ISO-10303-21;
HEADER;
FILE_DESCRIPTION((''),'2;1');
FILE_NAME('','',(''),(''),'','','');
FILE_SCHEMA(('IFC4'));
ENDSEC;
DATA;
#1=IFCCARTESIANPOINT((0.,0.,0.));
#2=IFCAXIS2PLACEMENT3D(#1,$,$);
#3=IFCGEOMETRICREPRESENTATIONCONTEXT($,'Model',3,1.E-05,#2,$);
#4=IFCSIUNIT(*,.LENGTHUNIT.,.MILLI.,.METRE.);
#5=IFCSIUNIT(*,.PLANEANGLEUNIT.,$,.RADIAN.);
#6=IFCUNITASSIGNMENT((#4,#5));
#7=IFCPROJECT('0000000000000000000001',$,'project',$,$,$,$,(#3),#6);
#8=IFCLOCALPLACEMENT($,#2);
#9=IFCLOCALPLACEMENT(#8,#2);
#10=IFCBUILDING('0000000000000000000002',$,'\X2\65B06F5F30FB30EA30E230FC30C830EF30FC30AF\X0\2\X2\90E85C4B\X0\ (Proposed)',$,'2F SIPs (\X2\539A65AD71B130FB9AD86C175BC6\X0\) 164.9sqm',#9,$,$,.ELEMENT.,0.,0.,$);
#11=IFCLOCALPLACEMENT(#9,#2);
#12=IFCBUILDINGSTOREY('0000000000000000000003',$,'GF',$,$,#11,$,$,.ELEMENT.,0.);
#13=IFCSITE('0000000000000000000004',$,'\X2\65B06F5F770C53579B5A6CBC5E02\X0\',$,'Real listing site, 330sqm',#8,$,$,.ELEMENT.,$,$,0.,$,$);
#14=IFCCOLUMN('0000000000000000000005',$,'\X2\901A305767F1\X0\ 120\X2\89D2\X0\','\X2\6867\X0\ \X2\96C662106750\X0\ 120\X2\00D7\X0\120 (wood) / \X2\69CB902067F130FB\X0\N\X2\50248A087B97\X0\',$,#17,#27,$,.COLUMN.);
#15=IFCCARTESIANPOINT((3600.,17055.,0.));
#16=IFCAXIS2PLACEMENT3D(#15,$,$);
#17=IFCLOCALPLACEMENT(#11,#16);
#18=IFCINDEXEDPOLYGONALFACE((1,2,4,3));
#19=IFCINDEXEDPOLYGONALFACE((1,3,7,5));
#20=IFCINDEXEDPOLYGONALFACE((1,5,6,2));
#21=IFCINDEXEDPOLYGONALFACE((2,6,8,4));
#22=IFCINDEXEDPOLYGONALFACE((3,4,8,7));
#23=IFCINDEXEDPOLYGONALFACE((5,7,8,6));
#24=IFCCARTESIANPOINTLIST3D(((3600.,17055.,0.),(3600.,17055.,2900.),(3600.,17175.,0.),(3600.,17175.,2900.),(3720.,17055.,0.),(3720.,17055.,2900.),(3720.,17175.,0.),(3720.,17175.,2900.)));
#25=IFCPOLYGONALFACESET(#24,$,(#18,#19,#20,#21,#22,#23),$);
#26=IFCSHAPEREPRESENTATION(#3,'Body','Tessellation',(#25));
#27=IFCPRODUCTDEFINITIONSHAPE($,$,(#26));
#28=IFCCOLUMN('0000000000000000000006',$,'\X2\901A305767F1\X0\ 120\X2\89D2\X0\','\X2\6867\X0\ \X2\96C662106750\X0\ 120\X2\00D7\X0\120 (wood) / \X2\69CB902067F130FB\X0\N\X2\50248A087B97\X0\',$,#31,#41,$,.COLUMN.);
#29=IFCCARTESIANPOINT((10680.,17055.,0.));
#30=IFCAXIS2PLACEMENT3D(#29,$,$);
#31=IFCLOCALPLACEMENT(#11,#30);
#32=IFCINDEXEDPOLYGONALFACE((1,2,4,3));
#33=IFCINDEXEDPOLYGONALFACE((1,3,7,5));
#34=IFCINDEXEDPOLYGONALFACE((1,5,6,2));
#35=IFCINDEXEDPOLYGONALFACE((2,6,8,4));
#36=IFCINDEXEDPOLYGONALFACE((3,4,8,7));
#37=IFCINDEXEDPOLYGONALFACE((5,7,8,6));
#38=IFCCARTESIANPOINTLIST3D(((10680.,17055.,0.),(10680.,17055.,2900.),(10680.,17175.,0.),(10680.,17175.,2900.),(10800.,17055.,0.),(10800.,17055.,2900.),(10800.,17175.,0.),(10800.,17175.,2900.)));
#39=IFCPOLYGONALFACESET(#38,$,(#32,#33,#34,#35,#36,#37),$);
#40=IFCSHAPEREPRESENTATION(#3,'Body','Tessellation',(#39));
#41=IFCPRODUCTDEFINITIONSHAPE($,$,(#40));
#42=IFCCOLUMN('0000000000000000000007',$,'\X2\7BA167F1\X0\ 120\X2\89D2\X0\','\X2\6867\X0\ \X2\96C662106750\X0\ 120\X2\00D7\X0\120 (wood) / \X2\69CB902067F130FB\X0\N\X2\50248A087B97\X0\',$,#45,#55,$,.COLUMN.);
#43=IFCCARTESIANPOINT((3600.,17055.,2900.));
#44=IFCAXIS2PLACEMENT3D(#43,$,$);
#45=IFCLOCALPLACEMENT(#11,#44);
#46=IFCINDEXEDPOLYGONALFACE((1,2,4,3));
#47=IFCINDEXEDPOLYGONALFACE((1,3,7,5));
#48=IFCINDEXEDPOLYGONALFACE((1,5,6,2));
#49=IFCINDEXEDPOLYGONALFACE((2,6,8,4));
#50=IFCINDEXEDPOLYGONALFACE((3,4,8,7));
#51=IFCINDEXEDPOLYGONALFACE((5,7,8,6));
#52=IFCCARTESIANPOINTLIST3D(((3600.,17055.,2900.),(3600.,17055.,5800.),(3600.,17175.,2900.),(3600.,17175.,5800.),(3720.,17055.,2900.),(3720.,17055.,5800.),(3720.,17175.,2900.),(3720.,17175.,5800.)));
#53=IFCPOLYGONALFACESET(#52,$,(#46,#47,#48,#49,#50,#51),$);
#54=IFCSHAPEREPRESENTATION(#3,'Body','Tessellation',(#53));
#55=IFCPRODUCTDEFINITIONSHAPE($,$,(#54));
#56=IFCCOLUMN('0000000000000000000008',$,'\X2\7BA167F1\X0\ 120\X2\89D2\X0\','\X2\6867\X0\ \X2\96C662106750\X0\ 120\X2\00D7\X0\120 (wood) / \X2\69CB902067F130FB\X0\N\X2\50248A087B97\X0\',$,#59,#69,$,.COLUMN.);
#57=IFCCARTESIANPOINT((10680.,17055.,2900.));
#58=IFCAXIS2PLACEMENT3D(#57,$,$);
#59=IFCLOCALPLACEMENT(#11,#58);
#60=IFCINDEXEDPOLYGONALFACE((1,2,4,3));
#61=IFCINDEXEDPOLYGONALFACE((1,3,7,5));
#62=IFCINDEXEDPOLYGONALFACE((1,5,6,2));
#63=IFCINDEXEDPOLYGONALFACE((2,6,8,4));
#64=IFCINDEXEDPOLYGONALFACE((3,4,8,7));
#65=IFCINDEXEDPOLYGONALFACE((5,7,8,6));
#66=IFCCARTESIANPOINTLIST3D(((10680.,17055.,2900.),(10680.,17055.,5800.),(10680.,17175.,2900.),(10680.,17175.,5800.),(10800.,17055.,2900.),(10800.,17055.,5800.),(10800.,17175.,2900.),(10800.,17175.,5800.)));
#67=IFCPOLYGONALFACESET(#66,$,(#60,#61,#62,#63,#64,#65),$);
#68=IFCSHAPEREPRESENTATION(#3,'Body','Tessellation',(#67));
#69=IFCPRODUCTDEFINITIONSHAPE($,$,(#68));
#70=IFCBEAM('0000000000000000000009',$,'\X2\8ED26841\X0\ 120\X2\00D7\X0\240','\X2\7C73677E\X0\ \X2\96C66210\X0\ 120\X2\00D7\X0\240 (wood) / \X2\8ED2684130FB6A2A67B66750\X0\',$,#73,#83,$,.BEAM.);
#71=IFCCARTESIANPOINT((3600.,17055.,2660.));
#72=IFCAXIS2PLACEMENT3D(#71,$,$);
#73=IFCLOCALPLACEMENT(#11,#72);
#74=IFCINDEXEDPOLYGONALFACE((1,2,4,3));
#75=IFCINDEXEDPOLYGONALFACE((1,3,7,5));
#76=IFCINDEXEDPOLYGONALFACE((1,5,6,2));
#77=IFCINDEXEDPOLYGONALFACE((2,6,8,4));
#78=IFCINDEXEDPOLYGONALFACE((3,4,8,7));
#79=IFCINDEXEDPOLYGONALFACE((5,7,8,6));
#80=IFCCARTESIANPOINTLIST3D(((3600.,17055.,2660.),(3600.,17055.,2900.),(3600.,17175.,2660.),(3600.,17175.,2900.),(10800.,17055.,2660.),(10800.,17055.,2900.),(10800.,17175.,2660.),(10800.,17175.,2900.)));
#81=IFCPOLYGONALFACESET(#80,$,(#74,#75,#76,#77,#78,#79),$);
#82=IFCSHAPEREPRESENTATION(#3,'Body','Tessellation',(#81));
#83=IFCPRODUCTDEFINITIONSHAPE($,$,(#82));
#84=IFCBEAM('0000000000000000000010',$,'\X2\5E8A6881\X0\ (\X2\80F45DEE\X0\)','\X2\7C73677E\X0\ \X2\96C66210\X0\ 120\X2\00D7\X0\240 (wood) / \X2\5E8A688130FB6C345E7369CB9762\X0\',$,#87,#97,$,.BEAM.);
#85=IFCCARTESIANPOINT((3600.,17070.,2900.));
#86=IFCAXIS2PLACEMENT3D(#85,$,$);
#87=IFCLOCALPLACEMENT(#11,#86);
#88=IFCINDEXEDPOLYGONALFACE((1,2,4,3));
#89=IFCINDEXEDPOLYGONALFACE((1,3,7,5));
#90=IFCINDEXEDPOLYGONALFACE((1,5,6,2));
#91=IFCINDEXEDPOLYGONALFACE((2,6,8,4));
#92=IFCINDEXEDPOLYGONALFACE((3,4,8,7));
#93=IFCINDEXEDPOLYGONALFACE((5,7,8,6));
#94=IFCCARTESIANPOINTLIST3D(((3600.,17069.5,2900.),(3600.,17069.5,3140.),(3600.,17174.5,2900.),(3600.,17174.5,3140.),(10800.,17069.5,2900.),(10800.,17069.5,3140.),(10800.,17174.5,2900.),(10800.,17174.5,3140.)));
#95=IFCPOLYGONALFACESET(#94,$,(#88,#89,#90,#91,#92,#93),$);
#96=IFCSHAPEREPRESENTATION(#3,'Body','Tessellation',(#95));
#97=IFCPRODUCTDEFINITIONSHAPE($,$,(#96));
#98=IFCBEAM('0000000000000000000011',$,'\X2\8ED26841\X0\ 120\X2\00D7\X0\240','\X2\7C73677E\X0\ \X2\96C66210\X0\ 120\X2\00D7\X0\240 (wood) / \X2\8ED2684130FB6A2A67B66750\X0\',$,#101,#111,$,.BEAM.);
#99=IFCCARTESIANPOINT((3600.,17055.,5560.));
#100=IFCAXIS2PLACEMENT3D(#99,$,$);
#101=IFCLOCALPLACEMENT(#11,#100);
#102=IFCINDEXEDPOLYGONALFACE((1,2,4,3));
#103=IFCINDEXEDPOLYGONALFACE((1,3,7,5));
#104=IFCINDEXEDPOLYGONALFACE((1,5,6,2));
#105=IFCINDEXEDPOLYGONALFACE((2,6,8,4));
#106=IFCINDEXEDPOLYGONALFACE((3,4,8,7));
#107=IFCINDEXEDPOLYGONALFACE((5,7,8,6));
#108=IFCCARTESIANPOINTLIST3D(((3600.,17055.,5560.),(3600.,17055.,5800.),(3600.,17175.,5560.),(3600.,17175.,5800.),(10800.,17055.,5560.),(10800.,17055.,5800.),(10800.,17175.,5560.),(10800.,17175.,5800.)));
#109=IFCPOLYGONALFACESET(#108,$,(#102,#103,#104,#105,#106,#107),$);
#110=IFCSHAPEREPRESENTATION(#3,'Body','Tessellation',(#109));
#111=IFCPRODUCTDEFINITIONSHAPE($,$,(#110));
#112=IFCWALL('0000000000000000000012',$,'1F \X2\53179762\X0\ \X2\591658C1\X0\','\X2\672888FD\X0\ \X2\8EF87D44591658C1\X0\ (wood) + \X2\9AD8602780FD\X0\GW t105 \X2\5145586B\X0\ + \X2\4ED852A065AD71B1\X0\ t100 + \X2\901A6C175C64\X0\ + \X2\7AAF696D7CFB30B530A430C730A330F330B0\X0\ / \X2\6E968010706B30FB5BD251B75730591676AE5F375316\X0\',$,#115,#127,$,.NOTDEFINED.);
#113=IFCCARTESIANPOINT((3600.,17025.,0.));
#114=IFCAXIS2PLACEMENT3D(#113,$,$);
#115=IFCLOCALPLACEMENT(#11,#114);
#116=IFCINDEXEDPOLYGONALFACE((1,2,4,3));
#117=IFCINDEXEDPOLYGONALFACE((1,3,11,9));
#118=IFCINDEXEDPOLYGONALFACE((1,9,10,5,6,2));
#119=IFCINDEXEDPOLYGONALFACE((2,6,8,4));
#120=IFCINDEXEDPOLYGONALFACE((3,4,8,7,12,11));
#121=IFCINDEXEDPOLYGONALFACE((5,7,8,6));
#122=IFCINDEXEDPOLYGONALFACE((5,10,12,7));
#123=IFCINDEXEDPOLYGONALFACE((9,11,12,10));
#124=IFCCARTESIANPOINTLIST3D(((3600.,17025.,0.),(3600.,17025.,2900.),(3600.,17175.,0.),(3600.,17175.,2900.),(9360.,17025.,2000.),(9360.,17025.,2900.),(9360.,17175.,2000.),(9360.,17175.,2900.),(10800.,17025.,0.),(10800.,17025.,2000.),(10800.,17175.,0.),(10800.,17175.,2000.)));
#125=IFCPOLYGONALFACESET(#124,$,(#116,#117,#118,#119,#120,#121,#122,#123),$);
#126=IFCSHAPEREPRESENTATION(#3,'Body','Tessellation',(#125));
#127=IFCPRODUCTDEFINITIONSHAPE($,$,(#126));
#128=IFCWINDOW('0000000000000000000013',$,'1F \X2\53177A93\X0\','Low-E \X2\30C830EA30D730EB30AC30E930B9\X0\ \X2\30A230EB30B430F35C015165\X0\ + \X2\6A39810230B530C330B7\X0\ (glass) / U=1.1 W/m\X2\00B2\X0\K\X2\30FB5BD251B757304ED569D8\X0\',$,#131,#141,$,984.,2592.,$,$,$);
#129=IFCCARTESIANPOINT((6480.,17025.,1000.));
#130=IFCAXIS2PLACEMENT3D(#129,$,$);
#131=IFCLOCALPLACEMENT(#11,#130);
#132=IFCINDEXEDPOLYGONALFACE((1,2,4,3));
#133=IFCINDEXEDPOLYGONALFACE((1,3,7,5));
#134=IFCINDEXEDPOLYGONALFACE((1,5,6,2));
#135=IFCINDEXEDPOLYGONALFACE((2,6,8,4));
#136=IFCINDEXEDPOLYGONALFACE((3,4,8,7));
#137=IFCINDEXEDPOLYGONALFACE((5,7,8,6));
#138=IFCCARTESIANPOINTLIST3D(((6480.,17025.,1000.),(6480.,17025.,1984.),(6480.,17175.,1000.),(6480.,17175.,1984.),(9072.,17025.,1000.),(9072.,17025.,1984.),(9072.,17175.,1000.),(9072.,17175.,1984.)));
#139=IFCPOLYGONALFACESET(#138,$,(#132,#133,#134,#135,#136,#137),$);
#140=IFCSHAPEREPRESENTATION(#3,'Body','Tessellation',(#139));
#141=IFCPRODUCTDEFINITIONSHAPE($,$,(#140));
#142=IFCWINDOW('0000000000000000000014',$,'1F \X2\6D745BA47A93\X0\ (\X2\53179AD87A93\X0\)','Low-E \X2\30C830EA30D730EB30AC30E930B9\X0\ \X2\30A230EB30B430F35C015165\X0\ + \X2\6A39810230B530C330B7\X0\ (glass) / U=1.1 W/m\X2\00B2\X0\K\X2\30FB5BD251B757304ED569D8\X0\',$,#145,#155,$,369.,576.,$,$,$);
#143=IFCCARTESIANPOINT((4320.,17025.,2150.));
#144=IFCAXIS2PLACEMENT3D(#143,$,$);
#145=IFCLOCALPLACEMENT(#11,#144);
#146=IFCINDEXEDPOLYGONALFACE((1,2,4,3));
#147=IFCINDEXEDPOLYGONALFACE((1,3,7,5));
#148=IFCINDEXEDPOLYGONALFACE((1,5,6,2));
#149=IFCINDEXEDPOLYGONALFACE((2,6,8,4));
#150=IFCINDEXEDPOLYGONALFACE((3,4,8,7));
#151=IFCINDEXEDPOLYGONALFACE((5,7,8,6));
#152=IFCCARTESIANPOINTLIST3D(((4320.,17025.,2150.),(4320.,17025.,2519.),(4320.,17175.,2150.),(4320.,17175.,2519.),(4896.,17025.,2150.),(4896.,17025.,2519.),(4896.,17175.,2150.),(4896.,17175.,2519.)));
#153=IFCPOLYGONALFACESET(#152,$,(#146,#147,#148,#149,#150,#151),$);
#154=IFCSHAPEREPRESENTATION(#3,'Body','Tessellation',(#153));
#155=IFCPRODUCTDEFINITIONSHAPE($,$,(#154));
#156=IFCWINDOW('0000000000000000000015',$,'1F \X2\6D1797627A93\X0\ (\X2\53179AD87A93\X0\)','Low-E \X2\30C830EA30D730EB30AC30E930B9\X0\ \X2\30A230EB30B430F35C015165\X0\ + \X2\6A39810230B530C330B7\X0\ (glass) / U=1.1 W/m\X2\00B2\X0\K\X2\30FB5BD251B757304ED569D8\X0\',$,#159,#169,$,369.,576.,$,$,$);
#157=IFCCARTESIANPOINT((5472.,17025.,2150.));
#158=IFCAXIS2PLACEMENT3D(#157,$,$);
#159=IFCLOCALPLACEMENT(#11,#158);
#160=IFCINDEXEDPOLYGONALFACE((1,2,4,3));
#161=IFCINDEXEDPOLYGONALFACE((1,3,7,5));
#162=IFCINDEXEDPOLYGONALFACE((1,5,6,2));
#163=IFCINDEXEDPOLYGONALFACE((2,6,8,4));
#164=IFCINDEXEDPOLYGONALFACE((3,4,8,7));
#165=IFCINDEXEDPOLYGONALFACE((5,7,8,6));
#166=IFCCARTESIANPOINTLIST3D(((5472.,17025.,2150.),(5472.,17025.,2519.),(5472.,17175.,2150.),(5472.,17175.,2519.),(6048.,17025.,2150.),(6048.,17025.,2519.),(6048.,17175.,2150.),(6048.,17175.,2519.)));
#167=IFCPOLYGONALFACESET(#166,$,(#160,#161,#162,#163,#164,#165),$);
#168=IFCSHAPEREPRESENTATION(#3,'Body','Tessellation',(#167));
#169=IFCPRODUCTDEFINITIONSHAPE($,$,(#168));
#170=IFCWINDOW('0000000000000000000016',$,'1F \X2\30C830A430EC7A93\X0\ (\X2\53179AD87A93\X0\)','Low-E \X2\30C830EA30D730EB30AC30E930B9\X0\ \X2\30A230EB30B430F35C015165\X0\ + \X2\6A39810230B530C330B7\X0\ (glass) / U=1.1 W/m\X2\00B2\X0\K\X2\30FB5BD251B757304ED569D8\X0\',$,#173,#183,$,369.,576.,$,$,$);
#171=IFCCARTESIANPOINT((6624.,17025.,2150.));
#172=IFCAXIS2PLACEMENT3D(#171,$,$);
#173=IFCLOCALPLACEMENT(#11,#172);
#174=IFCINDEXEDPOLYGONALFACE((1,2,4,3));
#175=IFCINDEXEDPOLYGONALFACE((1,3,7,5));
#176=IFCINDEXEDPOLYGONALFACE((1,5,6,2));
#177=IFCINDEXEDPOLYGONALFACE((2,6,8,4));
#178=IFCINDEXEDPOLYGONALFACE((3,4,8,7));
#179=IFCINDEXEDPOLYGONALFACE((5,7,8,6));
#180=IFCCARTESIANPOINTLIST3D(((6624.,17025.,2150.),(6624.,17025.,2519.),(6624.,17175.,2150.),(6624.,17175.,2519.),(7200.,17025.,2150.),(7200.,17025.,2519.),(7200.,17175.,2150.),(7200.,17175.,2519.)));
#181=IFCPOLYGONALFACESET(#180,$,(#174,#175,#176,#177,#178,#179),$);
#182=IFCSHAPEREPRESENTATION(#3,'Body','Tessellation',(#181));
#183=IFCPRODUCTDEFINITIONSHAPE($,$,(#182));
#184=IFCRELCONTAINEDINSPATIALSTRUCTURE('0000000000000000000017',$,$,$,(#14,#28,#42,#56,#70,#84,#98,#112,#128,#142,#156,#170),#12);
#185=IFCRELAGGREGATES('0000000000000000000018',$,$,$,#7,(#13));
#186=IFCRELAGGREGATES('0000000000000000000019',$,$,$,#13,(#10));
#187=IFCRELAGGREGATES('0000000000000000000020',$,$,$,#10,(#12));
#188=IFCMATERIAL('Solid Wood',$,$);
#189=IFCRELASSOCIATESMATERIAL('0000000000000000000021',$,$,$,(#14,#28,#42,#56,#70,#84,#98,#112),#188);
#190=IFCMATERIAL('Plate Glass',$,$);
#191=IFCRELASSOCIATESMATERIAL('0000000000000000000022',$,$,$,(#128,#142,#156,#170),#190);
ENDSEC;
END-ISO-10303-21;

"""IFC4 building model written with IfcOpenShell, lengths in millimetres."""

from ifc_helpers import new_model, si_unit, frame, frame_2d, origin, place, context, project, spatial, rectangle, extrude, material, element, fill, save


model = new_model("IFC4")

# Units and contexts
model_context = context("Model", 3, precision=1e-05, world=origin())
ifc_project = project(units=[si_unit("LENGTHUNIT", "METRE", prefix="MILLI"), si_unit("PLANEANGLEUNIT", "RADIAN")], contexts=[model_context])

# Site, building, storey
site_placement = place(None, origin())
site = spatial("IfcSite", under=ifc_project, at=site_placement, Name="新潟県南魚沼市", ObjectType="Real listing site, 330sqm", CompositionType="ELEMENT", RefElevation=0.0)
building_placement = place(site_placement, origin())
building = spatial("IfcBuilding", under=site, at=building_placement, Name="新潟・リモートワーク2部屋 (Proposed)", ObjectType="2F SIPs (厚断熱・高気密) 164.9sqm", CompositionType="ELEMENT", ElevationOfRefHeight=0.0, ElevationOfTerrain=0.0)
storey_placement = place(building_placement, origin())
storey = spatial("IfcBuildingStorey", under=building, at=storey_placement, Name="GF", CompositionType="ELEMENT", Elevation=0.0)

# Columns
ifc_material_1 = material(Name="Solid Wood")
column_1_placement = place(storey_placement, frame((3600.0, 17055.0, 0.0)))
element("IfcColumn", 1, at=column_1_placement, inside=storey, material=ifc_material_1, Name="通し柱 120角", Description="桧 集成材 120×120 (wood) / 構造柱・N値計算", PredefinedType="COLUMN", context=model_context, shape_type="SweptSolid", body=[
    extrude(rectangle(XDim=120.0, YDim=120.0, at=frame_2d((60.0, 60.0))), frame((3600.0, 17055.0, 0.0)), (0.0, 0.0, 1.0), 2900.0),
])
column_2_placement = place(storey_placement, frame((10680.0, 17055.0, 0.0)))
element("IfcColumn", 2, at=column_2_placement, inside=storey, material=ifc_material_1, Name="通し柱 120角", Description="桧 集成材 120×120 (wood) / 構造柱・N値計算", PredefinedType="COLUMN", context=model_context, shape_type="SweptSolid", body=[
    extrude(rectangle(XDim=120.0, YDim=120.0, at=frame_2d((60.0, 60.0))), frame((10680.0, 17055.0, 0.0)), (0.0, 0.0, 1.0), 2900.0),
])
column_3_placement = place(storey_placement, frame((3600.0, 17055.0, 2900.0)))
element("IfcColumn", 3, at=column_3_placement, inside=storey, material=ifc_material_1, Name="管柱 120角", Description="桧 集成材 120×120 (wood) / 構造柱・N値計算", PredefinedType="COLUMN", context=model_context, shape_type="SweptSolid", body=[
    extrude(rectangle(XDim=120.0, YDim=120.0, at=frame_2d((60.0, 60.0))), frame((3600.0, 17055.0, 2900.0)), (0.0, 0.0, 1.0), 2900.0),
])
column_4_placement = place(storey_placement, frame((10680.0, 17055.0, 2900.0)))
element("IfcColumn", 4, at=column_4_placement, inside=storey, material=ifc_material_1, Name="管柱 120角", Description="桧 集成材 120×120 (wood) / 構造柱・N値計算", PredefinedType="COLUMN", context=model_context, shape_type="SweptSolid", body=[
    extrude(rectangle(XDim=120.0, YDim=120.0, at=frame_2d((60.0, 60.0))), frame((10680.0, 17055.0, 2900.0)), (0.0, 0.0, 1.0), 2900.0),
])

# Beams
beam_1_placement = place(storey_placement, frame((3600.0, 17055.0, 2660.0)))
element("IfcBeam", 5, at=beam_1_placement, inside=storey, material=ifc_material_1, Name="軒桁 120×240", Description="米松 集成 120×240 (wood) / 軒桁・横架材", PredefinedType="BEAM", context=model_context, shape_type="SweptSolid", body=[
    extrude(rectangle(XDim=7200.0, YDim=120.0, at=frame_2d((3600.0, 60.0))), frame((3600.0, 17055.0, 2660.0)), (0.0, 0.0, 1.0), 240.0),
])
beam_2_placement = place(storey_placement, frame((3600.0, 17070.0, 2900.0)))
element("IfcBeam", 6, at=beam_2_placement, inside=storey, material=ifc_material_1, Name="床梁 (胴差)", Description="米松 集成 120×240 (wood) / 床梁・水平構面", PredefinedType="BEAM", context=model_context, shape_type="SweptSolid", body=[
    extrude(rectangle(XDim=7200.0, YDim=105.0, at=frame_2d((3600.0, 52.0))), frame((3600.0, 17070.0, 2900.0)), (0.0, 0.0, 1.0), 240.0),
])
beam_3_placement = place(storey_placement, frame((3600.0, 17055.0, 5560.0)))
element("IfcBeam", 7, at=beam_3_placement, inside=storey, material=ifc_material_1, Name="軒桁 120×240", Description="米松 集成 120×240 (wood) / 軒桁・横架材", PredefinedType="BEAM", context=model_context, shape_type="SweptSolid", body=[
    extrude(rectangle(XDim=7200.0, YDim=120.0, at=frame_2d((3600.0, 60.0))), frame((3600.0, 17055.0, 5560.0)), (0.0, 0.0, 1.0), 240.0),
])

# Wall, openings, windows
wall_1_placement = place(storey_placement, frame((3600.0, 17025.0, 0.0)))
wall_1 = element("IfcWall", 8, at=wall_1_placement, inside=storey, material=ifc_material_1, Name="1F 北面 外壁", Description="木製 軸組外壁 (wood) + 高性能GW t105 充填 + 付加断熱 t100 + 通気層 + 窯業系サイディング / 準耐火・寒冷地外皮強化", PredefinedType="NOTDEFINED", context=model_context, shape_type="SweptSolid", body=[
    extrude(rectangle(XDim=7200.0, YDim=150.0, at=frame_2d((3600.0, 75.0))), frame((3600.0, 17025.0, 0.0)), (0.0, 0.0, 1.0), 2900.0),
])
opening_1_placement = place(storey_placement, frame((6480.0, 17025.0, 1000.0)))
opening_1 = element("IfcOpeningElement", 9, at=opening_1_placement, cuts=wall_1, PredefinedType="NOTDEFINED", context=model_context, shape_type="SweptSolid", body=[
    extrude(rectangle(XDim=2592.0, YDim=150.0, at=frame_2d((1296.0, 75.0))), frame((6480.0, 17025.0, 1000.0)), (0.0, 0.0, 1.0), 984.0),
])
opening_2_placement = place(storey_placement, frame((4320.0, 17025.0, 2150.0)))
opening_2 = element("IfcOpeningElement", 10, at=opening_2_placement, cuts=wall_1, PredefinedType="NOTDEFINED", context=model_context, shape_type="SweptSolid", body=[
    extrude(rectangle(XDim=576.0, YDim=150.0, at=frame_2d((288.0, 75.0))), frame((4320.0, 17025.0, 2150.0)), (0.0, 0.0, 1.0), 369.0),
])
opening_3_placement = place(storey_placement, frame((5472.0, 17025.0, 2150.0)))
opening_3 = element("IfcOpeningElement", 11, at=opening_3_placement, cuts=wall_1, PredefinedType="NOTDEFINED", context=model_context, shape_type="SweptSolid", body=[
    extrude(rectangle(XDim=576.0, YDim=150.0, at=frame_2d((288.0, 75.0))), frame((5472.0, 17025.0, 2150.0)), (0.0, 0.0, 1.0), 369.0),
])
opening_4_placement = place(storey_placement, frame((6624.0, 17025.0, 2150.0)))
opening_4 = element("IfcOpeningElement", 12, at=opening_4_placement, cuts=wall_1, PredefinedType="NOTDEFINED", context=model_context, shape_type="SweptSolid", body=[
    extrude(rectangle(XDim=576.0, YDim=150.0, at=frame_2d((288.0, 75.0))), frame((6624.0, 17025.0, 2150.0)), (0.0, 0.0, 1.0), 369.0),
])
ifc_material_2 = material(Name="Plate Glass")
window_1_placement = place(storey_placement, frame((6480.0, 17025.0, 1000.0)))
window_1 = element("IfcWindow", 13, at=window_1_placement, inside=storey, material=ifc_material_2, Name="1F 北窓", Description="Low-E トリプルガラス アルゴン封入 + 樹脂サッシ (glass) / U=1.1 W/m²K・寒冷地仕様", OverallHeight=984.0, OverallWidth=2592.0, context=model_context, shape_type="SweptSolid", body=[
    extrude(rectangle(XDim=2592.0, YDim=150.0, at=frame_2d((1296.0, 75.0))), frame((6480.0, 17025.0, 1000.0)), (0.0, 0.0, 1.0), 984.0),
])
fill(opening_1, window_1)
window_2_placement = place(storey_placement, frame((4320.0, 17025.0, 2150.0)))
window_2 = element("IfcWindow", 14, at=window_2_placement, inside=storey, material=ifc_material_2, Name="1F 浴室窓 (北高窓)", Description="Low-E トリプルガラス アルゴン封入 + 樹脂サッシ (glass) / U=1.1 W/m²K・寒冷地仕様", OverallHeight=369.0, OverallWidth=576.0, context=model_context, shape_type="SweptSolid", body=[
    extrude(rectangle(XDim=576.0, YDim=150.0, at=frame_2d((288.0, 75.0))), frame((4320.0, 17025.0, 2150.0)), (0.0, 0.0, 1.0), 369.0),
])
fill(opening_2, window_2)
window_3_placement = place(storey_placement, frame((5472.0, 17025.0, 2150.0)))
window_3 = element("IfcWindow", 15, at=window_3_placement, inside=storey, material=ifc_material_2, Name="1F 洗面窓 (北高窓)", Description="Low-E トリプルガラス アルゴン封入 + 樹脂サッシ (glass) / U=1.1 W/m²K・寒冷地仕様", OverallHeight=369.0, OverallWidth=576.0, context=model_context, shape_type="SweptSolid", body=[
    extrude(rectangle(XDim=576.0, YDim=150.0, at=frame_2d((288.0, 75.0))), frame((5472.0, 17025.0, 2150.0)), (0.0, 0.0, 1.0), 369.0),
])
fill(opening_3, window_3)
window_4_placement = place(storey_placement, frame((6624.0, 17025.0, 2150.0)))
window_4 = element("IfcWindow", 16, at=window_4_placement, inside=storey, material=ifc_material_2, Name="1F トイレ窓 (北高窓)", Description="Low-E トリプルガラス アルゴン封入 + 樹脂サッシ (glass) / U=1.1 W/m²K・寒冷地仕様", OverallHeight=369.0, OverallWidth=576.0, context=model_context, shape_type="SweptSolid", body=[
    extrude(rectangle(XDim=576.0, YDim=150.0, at=frame_2d((288.0, 75.0))), frame((6624.0, 17025.0, 2150.0)), (0.0, 0.0, 1.0), 369.0),
])
fill(opening_4, window_4)

save(model, "model.ifc")
